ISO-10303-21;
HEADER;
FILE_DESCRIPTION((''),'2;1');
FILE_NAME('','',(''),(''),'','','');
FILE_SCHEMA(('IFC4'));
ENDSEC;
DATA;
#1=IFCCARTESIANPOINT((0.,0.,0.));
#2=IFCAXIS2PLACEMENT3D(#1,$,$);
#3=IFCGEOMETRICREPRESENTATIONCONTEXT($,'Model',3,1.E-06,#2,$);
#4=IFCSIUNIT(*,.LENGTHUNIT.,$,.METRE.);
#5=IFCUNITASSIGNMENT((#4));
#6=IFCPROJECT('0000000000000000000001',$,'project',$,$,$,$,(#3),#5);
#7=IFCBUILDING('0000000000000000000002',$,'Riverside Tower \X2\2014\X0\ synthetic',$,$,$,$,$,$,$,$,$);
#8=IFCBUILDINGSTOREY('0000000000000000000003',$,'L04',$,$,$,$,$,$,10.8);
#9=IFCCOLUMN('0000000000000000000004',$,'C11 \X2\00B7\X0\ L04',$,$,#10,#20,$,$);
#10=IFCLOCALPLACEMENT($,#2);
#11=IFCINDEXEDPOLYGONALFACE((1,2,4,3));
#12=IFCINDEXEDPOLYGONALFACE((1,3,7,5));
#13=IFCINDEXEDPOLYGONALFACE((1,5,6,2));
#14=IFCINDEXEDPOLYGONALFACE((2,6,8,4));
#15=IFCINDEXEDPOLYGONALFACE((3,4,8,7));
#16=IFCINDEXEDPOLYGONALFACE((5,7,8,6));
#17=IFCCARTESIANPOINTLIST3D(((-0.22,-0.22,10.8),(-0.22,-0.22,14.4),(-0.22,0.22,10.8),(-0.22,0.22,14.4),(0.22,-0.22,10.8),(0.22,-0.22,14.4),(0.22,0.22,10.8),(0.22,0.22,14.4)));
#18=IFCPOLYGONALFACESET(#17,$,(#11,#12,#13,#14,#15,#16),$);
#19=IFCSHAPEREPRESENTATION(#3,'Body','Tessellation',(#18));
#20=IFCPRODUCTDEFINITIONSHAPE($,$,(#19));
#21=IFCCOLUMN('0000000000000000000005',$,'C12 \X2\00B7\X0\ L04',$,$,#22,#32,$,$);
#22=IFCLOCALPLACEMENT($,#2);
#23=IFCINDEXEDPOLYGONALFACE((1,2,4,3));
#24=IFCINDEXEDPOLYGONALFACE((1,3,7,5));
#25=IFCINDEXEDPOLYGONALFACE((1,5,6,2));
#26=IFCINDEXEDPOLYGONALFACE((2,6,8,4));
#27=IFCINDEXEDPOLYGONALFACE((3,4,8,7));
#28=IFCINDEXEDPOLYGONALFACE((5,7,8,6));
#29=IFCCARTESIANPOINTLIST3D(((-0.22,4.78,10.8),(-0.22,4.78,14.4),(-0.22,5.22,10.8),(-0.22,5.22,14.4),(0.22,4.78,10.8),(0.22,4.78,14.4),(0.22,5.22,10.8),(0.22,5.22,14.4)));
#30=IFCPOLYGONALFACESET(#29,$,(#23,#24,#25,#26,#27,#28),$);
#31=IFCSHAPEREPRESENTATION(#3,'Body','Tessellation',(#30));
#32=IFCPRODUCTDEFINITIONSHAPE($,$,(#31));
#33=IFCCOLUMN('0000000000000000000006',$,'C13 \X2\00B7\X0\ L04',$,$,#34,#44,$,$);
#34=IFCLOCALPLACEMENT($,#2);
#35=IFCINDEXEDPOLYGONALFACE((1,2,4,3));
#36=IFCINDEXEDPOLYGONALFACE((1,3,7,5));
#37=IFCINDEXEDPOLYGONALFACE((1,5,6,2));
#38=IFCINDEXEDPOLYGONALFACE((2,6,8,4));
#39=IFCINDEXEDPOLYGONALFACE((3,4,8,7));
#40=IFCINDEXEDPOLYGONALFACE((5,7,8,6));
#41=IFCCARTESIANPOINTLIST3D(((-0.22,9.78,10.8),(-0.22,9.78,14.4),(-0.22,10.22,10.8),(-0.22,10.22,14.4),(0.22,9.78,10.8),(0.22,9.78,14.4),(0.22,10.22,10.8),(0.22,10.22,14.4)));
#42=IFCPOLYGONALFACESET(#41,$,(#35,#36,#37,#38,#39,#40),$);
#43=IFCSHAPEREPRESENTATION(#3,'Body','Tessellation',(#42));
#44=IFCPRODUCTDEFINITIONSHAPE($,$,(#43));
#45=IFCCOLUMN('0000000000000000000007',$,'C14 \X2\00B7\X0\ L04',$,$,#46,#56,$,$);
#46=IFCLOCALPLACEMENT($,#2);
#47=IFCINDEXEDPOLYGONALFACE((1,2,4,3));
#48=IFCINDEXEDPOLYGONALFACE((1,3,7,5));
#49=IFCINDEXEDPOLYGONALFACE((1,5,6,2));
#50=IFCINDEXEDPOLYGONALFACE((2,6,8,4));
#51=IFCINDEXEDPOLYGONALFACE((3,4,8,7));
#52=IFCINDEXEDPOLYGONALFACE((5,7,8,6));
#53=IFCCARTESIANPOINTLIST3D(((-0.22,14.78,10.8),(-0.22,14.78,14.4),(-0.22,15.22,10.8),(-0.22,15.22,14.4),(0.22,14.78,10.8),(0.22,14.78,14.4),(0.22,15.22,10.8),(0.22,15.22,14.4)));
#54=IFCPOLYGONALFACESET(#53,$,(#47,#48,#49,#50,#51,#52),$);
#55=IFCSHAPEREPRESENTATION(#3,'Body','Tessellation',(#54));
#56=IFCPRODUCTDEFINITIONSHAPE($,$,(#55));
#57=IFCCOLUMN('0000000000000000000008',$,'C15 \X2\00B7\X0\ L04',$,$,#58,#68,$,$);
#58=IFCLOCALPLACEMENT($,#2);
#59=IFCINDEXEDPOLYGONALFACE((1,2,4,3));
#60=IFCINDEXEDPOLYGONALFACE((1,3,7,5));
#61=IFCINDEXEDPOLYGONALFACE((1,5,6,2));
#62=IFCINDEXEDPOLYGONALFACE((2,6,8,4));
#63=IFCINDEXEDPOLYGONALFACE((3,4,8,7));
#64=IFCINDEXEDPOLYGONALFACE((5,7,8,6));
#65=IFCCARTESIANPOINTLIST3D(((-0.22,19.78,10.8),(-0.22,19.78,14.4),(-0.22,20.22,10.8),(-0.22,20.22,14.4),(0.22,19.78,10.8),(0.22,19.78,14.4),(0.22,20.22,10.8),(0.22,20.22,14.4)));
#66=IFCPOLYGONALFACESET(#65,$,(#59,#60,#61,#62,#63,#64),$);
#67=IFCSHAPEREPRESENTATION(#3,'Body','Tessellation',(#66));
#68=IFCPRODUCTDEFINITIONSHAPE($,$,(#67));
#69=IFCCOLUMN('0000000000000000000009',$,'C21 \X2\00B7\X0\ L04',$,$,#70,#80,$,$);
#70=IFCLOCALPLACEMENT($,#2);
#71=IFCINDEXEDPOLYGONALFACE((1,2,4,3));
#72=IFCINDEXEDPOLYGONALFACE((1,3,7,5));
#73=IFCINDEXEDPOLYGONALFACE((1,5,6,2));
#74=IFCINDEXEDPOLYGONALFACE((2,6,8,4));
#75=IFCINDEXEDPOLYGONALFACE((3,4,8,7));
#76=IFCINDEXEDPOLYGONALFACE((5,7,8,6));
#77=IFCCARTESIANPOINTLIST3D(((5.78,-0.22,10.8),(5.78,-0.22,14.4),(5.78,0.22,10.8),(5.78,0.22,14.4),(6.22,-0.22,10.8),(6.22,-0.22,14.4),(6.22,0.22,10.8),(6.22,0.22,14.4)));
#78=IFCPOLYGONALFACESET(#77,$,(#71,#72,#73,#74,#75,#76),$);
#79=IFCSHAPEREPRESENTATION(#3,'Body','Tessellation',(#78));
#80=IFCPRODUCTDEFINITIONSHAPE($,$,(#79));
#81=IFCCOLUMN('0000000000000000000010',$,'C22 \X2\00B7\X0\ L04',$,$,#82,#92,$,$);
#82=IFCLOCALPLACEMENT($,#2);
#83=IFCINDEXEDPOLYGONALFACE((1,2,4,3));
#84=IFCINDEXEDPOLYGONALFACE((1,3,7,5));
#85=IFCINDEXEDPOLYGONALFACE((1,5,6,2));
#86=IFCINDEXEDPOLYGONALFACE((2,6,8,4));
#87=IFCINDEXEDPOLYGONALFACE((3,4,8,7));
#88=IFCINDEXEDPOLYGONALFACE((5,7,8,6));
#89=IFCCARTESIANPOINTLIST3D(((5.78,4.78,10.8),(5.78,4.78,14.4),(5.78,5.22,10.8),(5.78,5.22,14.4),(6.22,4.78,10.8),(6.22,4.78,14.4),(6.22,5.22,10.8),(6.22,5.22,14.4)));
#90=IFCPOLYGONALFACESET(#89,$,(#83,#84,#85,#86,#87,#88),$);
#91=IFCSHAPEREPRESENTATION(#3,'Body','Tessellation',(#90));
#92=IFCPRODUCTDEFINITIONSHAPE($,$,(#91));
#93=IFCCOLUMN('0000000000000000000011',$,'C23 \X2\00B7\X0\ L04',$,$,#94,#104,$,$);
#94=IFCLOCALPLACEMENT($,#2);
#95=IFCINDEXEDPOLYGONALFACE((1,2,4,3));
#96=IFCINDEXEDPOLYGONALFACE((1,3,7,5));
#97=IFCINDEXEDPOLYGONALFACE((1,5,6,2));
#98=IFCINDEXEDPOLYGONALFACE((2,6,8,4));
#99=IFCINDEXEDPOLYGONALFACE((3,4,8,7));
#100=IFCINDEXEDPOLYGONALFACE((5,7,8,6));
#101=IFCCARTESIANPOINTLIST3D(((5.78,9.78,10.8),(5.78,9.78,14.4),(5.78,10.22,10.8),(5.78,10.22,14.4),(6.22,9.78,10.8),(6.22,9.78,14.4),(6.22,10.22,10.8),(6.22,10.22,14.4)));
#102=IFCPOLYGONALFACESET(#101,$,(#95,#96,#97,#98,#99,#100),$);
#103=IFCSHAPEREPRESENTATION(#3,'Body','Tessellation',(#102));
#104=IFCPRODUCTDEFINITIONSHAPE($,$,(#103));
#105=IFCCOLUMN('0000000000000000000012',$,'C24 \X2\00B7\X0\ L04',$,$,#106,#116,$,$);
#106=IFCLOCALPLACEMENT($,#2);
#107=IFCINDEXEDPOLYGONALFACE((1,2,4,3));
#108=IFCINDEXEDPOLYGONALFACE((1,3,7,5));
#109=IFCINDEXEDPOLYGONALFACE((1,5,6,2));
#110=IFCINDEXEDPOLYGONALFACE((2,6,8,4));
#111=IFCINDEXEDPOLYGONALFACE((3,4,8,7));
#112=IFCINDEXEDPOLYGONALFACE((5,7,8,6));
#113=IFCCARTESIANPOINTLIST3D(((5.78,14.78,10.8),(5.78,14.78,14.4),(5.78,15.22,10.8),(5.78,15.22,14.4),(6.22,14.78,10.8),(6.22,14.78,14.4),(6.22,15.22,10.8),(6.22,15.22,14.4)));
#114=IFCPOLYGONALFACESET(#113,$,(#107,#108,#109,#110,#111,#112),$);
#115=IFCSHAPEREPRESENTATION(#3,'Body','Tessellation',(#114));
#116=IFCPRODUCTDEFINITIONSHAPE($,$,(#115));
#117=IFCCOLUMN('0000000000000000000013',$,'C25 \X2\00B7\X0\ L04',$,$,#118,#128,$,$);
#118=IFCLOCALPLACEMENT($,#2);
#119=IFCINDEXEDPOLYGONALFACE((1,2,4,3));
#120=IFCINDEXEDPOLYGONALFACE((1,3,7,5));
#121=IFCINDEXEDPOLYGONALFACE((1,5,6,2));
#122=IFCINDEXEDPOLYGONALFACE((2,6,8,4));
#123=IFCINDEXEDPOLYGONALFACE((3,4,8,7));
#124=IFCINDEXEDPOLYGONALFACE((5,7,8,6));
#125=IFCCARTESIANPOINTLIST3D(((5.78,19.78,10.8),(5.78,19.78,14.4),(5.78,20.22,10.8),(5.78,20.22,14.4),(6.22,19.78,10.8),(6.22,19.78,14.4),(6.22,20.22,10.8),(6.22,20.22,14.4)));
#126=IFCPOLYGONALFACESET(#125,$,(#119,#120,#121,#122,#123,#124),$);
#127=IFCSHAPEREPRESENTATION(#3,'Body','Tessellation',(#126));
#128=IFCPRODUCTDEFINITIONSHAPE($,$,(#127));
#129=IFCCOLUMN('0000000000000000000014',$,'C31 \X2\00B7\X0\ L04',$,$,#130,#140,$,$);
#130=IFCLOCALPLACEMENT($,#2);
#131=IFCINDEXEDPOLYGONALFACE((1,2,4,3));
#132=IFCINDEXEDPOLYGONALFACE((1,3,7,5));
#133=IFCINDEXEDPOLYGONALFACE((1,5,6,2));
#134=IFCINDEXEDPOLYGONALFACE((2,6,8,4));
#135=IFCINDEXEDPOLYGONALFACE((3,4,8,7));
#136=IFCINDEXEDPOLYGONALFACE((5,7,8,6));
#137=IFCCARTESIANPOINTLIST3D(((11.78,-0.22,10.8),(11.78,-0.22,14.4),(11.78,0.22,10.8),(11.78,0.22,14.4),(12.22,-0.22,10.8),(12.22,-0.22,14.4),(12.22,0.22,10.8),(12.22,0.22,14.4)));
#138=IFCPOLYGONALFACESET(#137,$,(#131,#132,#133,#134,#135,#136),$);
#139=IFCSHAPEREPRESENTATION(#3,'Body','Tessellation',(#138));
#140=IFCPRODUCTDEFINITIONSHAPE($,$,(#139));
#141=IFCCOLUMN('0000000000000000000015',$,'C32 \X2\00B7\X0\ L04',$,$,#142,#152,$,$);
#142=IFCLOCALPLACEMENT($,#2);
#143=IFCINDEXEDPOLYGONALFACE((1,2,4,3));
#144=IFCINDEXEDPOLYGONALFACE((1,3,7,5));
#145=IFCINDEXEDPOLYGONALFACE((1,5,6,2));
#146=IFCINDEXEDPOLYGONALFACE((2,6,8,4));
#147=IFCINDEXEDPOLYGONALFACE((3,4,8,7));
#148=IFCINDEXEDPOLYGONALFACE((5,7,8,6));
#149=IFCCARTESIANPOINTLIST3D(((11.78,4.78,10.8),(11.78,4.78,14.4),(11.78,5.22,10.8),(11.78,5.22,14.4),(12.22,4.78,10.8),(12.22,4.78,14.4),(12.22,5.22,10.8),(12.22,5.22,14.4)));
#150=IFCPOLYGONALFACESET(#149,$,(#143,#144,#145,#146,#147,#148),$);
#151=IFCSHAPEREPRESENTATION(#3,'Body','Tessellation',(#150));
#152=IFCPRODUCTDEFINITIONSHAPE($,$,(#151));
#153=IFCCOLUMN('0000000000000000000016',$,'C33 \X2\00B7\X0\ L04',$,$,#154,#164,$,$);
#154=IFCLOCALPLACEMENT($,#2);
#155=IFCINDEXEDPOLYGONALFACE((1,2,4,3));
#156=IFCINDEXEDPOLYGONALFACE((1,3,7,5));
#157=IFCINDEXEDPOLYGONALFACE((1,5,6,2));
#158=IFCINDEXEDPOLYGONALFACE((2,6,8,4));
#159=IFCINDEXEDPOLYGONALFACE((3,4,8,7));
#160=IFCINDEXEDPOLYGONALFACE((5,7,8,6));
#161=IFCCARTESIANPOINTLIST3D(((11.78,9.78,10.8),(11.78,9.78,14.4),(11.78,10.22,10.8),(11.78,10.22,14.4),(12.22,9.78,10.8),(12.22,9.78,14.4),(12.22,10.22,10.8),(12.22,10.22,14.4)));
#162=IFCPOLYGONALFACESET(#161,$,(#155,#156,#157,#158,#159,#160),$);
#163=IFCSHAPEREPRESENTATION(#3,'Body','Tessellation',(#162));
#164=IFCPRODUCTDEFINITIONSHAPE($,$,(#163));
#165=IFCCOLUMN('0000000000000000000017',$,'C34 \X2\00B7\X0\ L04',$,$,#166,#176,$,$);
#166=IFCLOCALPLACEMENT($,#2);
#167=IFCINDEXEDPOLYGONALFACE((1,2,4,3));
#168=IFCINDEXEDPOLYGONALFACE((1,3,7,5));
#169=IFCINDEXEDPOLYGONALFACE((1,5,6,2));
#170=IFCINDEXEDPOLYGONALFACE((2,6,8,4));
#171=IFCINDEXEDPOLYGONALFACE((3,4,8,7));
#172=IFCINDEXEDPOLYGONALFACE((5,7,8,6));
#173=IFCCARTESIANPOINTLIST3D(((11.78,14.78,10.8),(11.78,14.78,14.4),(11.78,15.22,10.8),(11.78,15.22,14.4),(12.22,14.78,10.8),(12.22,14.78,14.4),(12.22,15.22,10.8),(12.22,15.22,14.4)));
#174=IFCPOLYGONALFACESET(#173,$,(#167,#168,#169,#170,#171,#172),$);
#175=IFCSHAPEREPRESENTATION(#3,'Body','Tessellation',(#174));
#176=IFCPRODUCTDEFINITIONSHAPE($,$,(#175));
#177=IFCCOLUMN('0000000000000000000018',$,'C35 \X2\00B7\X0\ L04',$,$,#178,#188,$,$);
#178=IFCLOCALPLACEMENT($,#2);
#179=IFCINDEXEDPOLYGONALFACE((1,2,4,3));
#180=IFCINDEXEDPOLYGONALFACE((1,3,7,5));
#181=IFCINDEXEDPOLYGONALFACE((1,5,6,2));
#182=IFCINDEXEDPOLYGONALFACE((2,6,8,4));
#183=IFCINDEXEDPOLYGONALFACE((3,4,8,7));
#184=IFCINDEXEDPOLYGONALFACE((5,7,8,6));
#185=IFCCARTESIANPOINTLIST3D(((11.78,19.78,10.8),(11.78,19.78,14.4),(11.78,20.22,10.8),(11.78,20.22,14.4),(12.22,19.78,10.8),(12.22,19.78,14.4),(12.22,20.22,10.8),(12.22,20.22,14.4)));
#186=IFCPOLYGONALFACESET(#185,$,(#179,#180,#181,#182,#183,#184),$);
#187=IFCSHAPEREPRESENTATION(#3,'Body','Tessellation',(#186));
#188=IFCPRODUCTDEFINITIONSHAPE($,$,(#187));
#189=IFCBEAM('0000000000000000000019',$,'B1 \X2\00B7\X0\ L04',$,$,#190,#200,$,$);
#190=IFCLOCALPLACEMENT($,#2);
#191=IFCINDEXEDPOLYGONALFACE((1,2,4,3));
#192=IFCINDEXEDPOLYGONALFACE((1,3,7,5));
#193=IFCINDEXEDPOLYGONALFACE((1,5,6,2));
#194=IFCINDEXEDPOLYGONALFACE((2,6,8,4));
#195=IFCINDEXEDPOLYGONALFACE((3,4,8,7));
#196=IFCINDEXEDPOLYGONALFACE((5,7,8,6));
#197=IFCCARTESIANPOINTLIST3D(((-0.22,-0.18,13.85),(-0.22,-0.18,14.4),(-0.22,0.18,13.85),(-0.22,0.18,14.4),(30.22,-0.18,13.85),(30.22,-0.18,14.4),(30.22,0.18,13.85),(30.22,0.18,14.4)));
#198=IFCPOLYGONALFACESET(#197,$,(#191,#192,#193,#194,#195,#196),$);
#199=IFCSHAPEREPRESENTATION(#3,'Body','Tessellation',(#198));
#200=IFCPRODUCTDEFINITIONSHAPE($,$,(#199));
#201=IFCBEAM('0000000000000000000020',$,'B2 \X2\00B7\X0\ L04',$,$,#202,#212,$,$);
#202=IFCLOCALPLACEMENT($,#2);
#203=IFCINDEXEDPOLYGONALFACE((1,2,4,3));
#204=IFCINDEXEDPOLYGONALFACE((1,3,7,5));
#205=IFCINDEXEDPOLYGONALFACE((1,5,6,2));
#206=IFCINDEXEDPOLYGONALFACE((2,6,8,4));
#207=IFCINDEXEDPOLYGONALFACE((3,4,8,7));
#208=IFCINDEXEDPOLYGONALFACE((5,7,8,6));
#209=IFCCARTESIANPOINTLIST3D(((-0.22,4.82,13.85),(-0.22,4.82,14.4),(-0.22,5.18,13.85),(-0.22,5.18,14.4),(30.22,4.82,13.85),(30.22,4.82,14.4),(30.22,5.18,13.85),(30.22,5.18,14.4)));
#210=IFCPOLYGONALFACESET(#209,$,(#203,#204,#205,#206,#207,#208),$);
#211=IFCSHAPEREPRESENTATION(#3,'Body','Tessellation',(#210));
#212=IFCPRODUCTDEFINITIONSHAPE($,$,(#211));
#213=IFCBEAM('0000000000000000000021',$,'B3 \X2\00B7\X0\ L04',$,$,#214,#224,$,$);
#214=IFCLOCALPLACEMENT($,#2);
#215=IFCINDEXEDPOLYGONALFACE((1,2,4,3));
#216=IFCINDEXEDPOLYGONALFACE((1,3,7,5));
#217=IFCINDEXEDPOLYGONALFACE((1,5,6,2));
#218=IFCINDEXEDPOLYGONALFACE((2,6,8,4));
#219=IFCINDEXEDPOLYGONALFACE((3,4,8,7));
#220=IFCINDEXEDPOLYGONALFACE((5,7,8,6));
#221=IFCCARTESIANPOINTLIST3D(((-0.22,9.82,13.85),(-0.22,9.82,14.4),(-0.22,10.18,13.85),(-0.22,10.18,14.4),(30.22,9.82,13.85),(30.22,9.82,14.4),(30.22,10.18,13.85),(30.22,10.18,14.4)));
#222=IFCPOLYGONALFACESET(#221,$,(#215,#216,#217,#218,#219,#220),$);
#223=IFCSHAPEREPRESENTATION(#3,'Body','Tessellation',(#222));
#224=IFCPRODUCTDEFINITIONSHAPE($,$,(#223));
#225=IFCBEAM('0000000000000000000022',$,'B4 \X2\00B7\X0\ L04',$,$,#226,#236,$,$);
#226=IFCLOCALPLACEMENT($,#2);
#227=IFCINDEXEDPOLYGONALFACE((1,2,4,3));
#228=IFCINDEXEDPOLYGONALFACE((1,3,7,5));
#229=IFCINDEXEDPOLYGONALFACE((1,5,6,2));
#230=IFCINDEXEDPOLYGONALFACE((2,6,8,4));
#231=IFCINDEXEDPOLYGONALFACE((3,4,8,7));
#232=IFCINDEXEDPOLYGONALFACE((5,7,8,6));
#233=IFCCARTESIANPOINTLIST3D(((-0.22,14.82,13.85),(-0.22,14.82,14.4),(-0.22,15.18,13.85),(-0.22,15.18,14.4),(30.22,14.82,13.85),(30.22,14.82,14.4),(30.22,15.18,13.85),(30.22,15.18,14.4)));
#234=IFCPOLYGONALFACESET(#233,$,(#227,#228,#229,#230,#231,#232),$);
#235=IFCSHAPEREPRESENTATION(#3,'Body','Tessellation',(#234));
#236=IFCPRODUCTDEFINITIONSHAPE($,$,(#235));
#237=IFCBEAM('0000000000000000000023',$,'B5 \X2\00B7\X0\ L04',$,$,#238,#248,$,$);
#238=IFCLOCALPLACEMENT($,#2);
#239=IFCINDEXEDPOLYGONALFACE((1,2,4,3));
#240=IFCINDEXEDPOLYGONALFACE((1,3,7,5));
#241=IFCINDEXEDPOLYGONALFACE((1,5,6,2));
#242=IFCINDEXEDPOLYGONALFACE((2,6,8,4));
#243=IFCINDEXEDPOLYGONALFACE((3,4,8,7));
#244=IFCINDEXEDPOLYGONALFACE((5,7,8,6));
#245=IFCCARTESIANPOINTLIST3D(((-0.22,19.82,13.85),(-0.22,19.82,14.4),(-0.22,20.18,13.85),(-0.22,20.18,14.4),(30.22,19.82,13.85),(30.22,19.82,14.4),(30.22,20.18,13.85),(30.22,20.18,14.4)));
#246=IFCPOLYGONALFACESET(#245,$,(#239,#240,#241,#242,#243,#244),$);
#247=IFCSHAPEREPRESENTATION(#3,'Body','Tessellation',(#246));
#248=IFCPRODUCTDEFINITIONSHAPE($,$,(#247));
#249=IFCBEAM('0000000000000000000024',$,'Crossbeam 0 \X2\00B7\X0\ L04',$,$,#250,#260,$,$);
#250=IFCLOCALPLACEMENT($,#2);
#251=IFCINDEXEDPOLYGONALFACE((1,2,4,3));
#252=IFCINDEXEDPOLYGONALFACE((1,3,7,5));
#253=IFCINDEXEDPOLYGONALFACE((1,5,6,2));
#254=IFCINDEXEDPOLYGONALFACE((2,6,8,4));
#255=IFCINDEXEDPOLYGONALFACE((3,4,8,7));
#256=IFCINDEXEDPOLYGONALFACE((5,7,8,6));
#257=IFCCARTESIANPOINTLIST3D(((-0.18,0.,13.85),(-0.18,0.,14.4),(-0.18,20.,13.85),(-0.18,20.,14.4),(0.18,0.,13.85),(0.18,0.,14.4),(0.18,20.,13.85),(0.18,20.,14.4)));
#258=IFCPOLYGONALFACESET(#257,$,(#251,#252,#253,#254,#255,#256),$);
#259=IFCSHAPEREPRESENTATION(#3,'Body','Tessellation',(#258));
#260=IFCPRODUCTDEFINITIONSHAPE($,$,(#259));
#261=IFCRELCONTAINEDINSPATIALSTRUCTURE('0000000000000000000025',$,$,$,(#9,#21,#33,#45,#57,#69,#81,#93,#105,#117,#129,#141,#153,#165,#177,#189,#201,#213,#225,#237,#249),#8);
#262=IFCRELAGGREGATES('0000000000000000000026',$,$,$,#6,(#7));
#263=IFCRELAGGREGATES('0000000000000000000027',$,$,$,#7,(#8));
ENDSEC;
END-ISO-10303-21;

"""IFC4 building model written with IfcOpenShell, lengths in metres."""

from ifc_helpers import new_model, si_unit, frame, origin, place, context, project, spatial, rectangle, extrude, element, save


model = new_model("IFC4")

# Units and contexts
model_context = context("Model", 3, precision=1e-06, world=origin())
ifc_project = project(units=[si_unit("LENGTHUNIT", "METRE")], contexts=[model_context])

# Building, storey
building = spatial("IfcBuilding", under=ifc_project, Name="Riverside Tower — synthetic")
storey = spatial("IfcBuildingStorey", under=building, Name="L04", Elevation=10.8)

# Columns
for number, where, name in (
    (1, (0.0, 0.0, 10.8), "C11 · L04"),
    (2, (0.0, 5.0, 10.8), "C12 · L04"),
    (3, (0.0, 10.0, 10.8), "C13 · L04"),
    (4, (0.0, 15.0, 10.8), "C14 · L04"),
    (5, (0.0, 20.0, 10.8), "C15 · L04"),
    (6, (6.0, 0.0, 10.8), "C21 · L04"),
    (7, (6.0, 5.0, 10.8), "C22 · L04"),
    (8, (6.0, 10.0, 10.8), "C23 · L04"),
    (9, (6.0, 15.0, 10.8), "C24 · L04"),
    (10, (6.0, 20.0, 10.8), "C25 · L04"),
    (11, (12.0, 0.0, 10.8), "C31 · L04"),
    (12, (12.0, 5.0, 10.8), "C32 · L04"),
    (13, (12.0, 10.0, 10.8), "C33 · L04"),
    (14, (12.0, 15.0, 10.8), "C34 · L04"),
    (15, (12.0, 20.0, 10.8), "C35 · L04"),
):
    element("IfcColumn", number, at=place(None, frame(where)), inside=storey, Name=name, context=model_context, shape_type="SweptSolid", body=[
        extrude(rectangle(XDim=0.44, YDim=0.44), origin(), (0.0, 0.0, 1.0), 3.6),
    ])

# Beams
for number, where, name in (
    (16, (15.0, 0.0, 13.85), "B1 · L04"),
    (17, (15.0, 5.0, 13.85), "B2 · L04"),
    (18, (15.0, 10.0, 13.85), "B3 · L04"),
    (19, (15.0, 15.0, 13.85), "B4 · L04"),
    (20, (15.0, 20.0, 13.85), "B5 · L04"),
):
    element("IfcBeam", number, at=place(None, frame(where)), inside=storey, Name=name, context=model_context, shape_type="SweptSolid", body=[
        extrude(rectangle(XDim=30.44, YDim=0.36), origin(), (0.0, 0.0, 1.0), 0.55),
    ])
for number, where, name in (
    (21, (0.0, 10.0, 13.85), "Crossbeam 0 · L04"),
):
    element("IfcBeam", number, at=place(None, frame(where)), inside=storey, Name=name, context=model_context, shape_type="SweptSolid", body=[
        extrude(rectangle(XDim=0.36, YDim=20.0), origin(), (0.0, 0.0, 1.0), 0.55),
    ])

save(model, "model.ifc")
